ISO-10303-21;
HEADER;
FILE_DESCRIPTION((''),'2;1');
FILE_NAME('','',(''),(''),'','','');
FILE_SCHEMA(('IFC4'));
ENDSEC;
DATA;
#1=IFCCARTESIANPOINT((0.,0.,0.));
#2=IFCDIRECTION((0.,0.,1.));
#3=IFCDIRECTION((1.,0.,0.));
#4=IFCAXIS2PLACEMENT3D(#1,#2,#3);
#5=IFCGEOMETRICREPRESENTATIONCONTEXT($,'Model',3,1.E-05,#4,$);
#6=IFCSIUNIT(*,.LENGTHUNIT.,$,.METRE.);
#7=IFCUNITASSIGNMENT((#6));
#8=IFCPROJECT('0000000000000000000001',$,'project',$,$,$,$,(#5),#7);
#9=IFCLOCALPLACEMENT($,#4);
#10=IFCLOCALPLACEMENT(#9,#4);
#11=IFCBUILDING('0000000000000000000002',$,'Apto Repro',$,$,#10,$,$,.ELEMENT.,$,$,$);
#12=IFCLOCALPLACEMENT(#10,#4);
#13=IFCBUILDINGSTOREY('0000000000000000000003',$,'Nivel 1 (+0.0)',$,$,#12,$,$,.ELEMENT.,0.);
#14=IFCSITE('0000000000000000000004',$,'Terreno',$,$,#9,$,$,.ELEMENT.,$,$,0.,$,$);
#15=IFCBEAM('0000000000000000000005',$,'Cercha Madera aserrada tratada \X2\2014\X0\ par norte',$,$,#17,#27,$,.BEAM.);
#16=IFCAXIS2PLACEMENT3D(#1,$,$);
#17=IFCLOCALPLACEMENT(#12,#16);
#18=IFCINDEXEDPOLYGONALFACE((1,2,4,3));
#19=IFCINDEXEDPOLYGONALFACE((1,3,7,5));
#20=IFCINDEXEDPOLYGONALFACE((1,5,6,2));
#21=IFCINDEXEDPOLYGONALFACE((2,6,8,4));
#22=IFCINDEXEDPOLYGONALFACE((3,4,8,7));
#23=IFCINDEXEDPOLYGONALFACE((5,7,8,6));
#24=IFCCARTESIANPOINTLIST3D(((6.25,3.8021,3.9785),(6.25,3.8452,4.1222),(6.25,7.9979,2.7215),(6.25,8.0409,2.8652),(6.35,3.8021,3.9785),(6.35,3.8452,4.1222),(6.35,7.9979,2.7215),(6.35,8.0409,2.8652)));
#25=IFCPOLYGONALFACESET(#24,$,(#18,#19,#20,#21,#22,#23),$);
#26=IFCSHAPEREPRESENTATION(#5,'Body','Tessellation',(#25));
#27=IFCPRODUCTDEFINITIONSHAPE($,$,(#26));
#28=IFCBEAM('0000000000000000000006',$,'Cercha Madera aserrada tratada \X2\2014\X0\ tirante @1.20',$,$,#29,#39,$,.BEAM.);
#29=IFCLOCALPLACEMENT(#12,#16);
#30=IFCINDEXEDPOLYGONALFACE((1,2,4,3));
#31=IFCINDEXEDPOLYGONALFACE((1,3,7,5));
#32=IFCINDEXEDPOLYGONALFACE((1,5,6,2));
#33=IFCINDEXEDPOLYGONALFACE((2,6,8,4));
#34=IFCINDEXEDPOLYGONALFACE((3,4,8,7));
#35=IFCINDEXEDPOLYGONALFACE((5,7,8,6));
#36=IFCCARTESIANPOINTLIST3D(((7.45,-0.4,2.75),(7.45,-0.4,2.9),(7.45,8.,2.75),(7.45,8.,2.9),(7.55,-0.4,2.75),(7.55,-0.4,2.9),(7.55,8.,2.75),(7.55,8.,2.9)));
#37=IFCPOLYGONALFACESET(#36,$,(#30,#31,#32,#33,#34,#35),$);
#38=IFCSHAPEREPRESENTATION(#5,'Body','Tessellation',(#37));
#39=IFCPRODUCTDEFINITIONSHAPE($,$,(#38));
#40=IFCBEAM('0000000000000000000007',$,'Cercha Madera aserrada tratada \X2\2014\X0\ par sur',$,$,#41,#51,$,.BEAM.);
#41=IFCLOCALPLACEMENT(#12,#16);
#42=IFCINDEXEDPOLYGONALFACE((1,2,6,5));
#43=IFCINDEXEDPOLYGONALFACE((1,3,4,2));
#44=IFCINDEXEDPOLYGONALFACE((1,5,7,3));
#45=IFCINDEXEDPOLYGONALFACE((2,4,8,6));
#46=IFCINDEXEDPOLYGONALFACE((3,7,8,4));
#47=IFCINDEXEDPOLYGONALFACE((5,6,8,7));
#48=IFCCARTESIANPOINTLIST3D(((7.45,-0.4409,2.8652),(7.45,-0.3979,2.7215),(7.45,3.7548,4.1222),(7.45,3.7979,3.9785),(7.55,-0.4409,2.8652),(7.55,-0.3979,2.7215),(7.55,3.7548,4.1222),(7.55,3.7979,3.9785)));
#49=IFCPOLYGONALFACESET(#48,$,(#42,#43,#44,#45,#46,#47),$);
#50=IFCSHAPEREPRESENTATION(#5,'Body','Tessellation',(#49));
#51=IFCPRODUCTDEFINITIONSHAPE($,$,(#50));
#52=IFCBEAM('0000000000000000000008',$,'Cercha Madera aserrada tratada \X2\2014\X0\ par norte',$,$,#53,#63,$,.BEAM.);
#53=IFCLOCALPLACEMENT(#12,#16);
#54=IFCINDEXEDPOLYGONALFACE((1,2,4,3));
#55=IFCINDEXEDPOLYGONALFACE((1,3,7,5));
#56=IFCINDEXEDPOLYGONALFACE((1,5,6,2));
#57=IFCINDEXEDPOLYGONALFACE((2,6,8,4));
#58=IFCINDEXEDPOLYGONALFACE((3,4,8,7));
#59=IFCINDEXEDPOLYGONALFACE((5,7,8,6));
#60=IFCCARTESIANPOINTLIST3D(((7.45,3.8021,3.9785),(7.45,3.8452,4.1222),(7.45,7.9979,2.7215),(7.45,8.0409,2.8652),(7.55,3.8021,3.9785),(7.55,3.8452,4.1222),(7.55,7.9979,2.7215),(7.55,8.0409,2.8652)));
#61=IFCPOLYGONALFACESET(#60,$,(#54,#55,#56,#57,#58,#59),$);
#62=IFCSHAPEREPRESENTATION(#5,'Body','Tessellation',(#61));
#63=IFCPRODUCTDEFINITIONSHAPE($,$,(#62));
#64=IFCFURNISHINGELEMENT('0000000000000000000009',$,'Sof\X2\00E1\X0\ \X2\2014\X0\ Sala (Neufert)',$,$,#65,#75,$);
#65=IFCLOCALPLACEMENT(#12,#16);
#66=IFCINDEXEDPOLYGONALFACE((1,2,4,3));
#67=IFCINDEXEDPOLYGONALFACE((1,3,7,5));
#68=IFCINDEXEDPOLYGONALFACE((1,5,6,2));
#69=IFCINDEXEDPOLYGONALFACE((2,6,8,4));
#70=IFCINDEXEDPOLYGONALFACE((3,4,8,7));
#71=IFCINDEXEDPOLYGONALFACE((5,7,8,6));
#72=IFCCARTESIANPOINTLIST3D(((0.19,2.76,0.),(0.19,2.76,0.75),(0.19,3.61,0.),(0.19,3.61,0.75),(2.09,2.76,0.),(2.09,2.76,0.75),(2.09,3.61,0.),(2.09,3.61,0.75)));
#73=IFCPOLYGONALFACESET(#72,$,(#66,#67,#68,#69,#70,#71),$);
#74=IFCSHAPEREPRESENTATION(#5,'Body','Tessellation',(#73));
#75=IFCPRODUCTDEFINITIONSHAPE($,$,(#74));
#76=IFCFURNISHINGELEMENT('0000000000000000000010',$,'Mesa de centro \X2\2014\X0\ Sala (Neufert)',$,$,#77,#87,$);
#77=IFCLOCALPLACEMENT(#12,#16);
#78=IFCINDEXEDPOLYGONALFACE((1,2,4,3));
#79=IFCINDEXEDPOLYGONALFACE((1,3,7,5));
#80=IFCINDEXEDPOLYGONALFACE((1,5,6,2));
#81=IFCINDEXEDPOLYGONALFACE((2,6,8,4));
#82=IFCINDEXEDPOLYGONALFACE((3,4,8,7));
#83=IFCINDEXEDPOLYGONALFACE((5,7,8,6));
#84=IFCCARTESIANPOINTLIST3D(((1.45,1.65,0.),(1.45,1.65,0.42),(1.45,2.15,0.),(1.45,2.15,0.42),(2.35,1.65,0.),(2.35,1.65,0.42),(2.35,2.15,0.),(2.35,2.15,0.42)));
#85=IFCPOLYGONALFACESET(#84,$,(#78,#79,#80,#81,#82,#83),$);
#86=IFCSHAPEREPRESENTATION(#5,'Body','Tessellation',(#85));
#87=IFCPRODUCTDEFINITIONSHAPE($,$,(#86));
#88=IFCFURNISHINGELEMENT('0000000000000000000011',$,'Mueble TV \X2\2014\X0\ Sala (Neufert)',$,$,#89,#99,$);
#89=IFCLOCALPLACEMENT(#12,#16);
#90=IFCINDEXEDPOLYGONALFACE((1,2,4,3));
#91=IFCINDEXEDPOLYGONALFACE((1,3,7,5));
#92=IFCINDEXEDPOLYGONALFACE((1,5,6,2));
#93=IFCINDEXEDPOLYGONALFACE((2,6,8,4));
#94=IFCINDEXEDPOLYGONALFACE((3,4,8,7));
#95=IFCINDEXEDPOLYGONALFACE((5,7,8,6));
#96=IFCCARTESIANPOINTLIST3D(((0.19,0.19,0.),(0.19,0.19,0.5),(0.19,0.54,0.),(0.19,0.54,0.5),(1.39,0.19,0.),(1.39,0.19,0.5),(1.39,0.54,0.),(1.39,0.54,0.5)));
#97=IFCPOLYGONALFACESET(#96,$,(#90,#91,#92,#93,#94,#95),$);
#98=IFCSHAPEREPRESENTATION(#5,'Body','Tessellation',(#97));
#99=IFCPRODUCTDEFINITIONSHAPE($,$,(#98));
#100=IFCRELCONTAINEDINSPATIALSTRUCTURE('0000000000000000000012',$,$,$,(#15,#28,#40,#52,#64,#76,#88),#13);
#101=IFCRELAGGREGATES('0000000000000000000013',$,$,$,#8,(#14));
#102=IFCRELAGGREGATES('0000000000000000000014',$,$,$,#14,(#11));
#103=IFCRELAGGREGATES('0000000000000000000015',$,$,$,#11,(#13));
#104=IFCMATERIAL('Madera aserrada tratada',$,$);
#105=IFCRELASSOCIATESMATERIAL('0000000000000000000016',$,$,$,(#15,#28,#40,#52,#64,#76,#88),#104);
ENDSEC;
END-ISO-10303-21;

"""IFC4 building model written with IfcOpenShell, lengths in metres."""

from ifc_helpers import new_model, si_unit, frame, origin_with_axes, origin_2d_with_axis, place, context, project, spatial, rectangle, extrude, material, element, save


model = new_model("IFC4")

# Units and contexts
model_context = context("Model", 3, precision=1e-05, world=origin_with_axes())
ifc_project = project(units=[si_unit("LENGTHUNIT", "METRE")], contexts=[model_context])

# Site, building, storey
site_placement = place(None, origin_with_axes())
site = spatial("IfcSite", under=ifc_project, at=site_placement, Name="Terreno", CompositionType="ELEMENT", RefElevation=0.0)
building_placement = place(site_placement, origin_with_axes())
building = spatial("IfcBuilding", under=site, at=building_placement, Name="Apto Repro", CompositionType="ELEMENT")
storey_placement = place(building_placement, origin_with_axes())
storey = spatial("IfcBuildingStorey", under=building, at=storey_placement, Name="Nivel 1 (+0.0)", CompositionType="ELEMENT", Elevation=0.0)

# Beams
ifc_material = material(Name="Madera aserrada tratada")
beam_1_placement = place(storey_placement, origin_with_axes())
element("IfcBeam", 1, at=beam_1_placement, inside=storey, material=ifc_material, Name="Cercha Madera aserrada tratada — par norte", PredefinedType="BEAM", context=model_context, shape_type="SweptSolid", body=[
    extrude(rectangle(XDim=0.1, YDim=4.38, at=origin_2d_with_axis()), frame((6.3, 5.9, 3.35), z_axis=(0.0, 0.287, 0.958), x_axis=(1.0, 0.0, 0.0)), (0.0, 0.0, 1.0), 0.15),
])
beam_2_placement = place(storey_placement, origin_with_axes())
element("IfcBeam", 2, at=beam_2_placement, inside=storey, material=ifc_material, Name="Cercha Madera aserrada tratada — tirante @1.20", PredefinedType="BEAM", context=model_context, shape_type="SweptSolid", body=[
    extrude(rectangle(XDim=8.4, YDim=0.1, at=origin_2d_with_axis()), frame((7.5, 3.8, 2.75), z_axis=(0.0, 0.0, 1.0), x_axis=(0.0, 1.0, 0.0)), (0.0, 0.0, 1.0), 0.15),
])
beam_3_placement = place(storey_placement, origin_with_axes())
element("IfcBeam", 3, at=beam_3_placement, inside=storey, material=ifc_material, Name="Cercha Madera aserrada tratada — par sur", PredefinedType="BEAM", context=model_context, shape_type="SweptSolid", body=[
    extrude(rectangle(XDim=0.1, YDim=4.38, at=origin_2d_with_axis()), frame((7.5, 1.7, 3.35), z_axis=(0.0, -0.287, 0.958), x_axis=(1.0, 0.0, 0.0)), (0.0, 0.0, 1.0), 0.15),
])
beam_4_placement = place(storey_placement, origin_with_axes())
element("IfcBeam", 4, at=beam_4_placement, inside=storey, material=ifc_material, Name="Cercha Madera aserrada tratada — par norte", PredefinedType="BEAM", context=model_context, shape_type="SweptSolid", body=[
    extrude(rectangle(XDim=0.1, YDim=4.38, at=origin_2d_with_axis()), frame((7.5, 5.9, 3.35), z_axis=(0.0, 0.287, 0.958), x_axis=(1.0, 0.0, 0.0)), (0.0, 0.0, 1.0), 0.15),
])

# Furnishing elements
furnishing_1_placement = place(storey_placement, origin_with_axes())
element("IfcFurnishingElement", 5, at=furnishing_1_placement, inside=storey, material=ifc_material, Name="Sofá — Sala (Neufert)", context=model_context, shape_type="SweptSolid", body=[
    extrude(rectangle(XDim=1.9, YDim=0.85, at=origin_2d_with_axis()), frame((1.14, 3.185, 0.0), z_axis=(0.0, 0.0, 1.0), x_axis=(1.0, 0.0, 0.0)), (0.0, 0.0, 1.0), 0.75),
])
furnishing_2_placement = place(storey_placement, origin_with_axes())
element("IfcFurnishingElement", 6, at=furnishing_2_placement, inside=storey, material=ifc_material, Name="Mesa de centro — Sala (Neufert)", context=model_context, shape_type="SweptSolid", body=[
    extrude(rectangle(XDim=0.9, YDim=0.5, at=origin_2d_with_axis()), frame((1.9, 1.9, 0.0), z_axis=(0.0, 0.0, 1.0), x_axis=(1.0, 0.0, 0.0)), (0.0, 0.0, 1.0), 0.42),
])
furnishing_3_placement = place(storey_placement, origin_with_axes())
element("IfcFurnishingElement", 7, at=furnishing_3_placement, inside=storey, material=ifc_material, Name="Mueble TV — Sala (Neufert)", context=model_context, shape_type="SweptSolid", body=[
    extrude(rectangle(XDim=1.2, YDim=0.35, at=origin_2d_with_axis()), frame((0.79, 0.365, 0.0), z_axis=(0.0, 0.0, 1.0), x_axis=(1.0, 0.0, 0.0)), (0.0, 0.0, 1.0), 0.5),
])

save(model, "model.ifc")
